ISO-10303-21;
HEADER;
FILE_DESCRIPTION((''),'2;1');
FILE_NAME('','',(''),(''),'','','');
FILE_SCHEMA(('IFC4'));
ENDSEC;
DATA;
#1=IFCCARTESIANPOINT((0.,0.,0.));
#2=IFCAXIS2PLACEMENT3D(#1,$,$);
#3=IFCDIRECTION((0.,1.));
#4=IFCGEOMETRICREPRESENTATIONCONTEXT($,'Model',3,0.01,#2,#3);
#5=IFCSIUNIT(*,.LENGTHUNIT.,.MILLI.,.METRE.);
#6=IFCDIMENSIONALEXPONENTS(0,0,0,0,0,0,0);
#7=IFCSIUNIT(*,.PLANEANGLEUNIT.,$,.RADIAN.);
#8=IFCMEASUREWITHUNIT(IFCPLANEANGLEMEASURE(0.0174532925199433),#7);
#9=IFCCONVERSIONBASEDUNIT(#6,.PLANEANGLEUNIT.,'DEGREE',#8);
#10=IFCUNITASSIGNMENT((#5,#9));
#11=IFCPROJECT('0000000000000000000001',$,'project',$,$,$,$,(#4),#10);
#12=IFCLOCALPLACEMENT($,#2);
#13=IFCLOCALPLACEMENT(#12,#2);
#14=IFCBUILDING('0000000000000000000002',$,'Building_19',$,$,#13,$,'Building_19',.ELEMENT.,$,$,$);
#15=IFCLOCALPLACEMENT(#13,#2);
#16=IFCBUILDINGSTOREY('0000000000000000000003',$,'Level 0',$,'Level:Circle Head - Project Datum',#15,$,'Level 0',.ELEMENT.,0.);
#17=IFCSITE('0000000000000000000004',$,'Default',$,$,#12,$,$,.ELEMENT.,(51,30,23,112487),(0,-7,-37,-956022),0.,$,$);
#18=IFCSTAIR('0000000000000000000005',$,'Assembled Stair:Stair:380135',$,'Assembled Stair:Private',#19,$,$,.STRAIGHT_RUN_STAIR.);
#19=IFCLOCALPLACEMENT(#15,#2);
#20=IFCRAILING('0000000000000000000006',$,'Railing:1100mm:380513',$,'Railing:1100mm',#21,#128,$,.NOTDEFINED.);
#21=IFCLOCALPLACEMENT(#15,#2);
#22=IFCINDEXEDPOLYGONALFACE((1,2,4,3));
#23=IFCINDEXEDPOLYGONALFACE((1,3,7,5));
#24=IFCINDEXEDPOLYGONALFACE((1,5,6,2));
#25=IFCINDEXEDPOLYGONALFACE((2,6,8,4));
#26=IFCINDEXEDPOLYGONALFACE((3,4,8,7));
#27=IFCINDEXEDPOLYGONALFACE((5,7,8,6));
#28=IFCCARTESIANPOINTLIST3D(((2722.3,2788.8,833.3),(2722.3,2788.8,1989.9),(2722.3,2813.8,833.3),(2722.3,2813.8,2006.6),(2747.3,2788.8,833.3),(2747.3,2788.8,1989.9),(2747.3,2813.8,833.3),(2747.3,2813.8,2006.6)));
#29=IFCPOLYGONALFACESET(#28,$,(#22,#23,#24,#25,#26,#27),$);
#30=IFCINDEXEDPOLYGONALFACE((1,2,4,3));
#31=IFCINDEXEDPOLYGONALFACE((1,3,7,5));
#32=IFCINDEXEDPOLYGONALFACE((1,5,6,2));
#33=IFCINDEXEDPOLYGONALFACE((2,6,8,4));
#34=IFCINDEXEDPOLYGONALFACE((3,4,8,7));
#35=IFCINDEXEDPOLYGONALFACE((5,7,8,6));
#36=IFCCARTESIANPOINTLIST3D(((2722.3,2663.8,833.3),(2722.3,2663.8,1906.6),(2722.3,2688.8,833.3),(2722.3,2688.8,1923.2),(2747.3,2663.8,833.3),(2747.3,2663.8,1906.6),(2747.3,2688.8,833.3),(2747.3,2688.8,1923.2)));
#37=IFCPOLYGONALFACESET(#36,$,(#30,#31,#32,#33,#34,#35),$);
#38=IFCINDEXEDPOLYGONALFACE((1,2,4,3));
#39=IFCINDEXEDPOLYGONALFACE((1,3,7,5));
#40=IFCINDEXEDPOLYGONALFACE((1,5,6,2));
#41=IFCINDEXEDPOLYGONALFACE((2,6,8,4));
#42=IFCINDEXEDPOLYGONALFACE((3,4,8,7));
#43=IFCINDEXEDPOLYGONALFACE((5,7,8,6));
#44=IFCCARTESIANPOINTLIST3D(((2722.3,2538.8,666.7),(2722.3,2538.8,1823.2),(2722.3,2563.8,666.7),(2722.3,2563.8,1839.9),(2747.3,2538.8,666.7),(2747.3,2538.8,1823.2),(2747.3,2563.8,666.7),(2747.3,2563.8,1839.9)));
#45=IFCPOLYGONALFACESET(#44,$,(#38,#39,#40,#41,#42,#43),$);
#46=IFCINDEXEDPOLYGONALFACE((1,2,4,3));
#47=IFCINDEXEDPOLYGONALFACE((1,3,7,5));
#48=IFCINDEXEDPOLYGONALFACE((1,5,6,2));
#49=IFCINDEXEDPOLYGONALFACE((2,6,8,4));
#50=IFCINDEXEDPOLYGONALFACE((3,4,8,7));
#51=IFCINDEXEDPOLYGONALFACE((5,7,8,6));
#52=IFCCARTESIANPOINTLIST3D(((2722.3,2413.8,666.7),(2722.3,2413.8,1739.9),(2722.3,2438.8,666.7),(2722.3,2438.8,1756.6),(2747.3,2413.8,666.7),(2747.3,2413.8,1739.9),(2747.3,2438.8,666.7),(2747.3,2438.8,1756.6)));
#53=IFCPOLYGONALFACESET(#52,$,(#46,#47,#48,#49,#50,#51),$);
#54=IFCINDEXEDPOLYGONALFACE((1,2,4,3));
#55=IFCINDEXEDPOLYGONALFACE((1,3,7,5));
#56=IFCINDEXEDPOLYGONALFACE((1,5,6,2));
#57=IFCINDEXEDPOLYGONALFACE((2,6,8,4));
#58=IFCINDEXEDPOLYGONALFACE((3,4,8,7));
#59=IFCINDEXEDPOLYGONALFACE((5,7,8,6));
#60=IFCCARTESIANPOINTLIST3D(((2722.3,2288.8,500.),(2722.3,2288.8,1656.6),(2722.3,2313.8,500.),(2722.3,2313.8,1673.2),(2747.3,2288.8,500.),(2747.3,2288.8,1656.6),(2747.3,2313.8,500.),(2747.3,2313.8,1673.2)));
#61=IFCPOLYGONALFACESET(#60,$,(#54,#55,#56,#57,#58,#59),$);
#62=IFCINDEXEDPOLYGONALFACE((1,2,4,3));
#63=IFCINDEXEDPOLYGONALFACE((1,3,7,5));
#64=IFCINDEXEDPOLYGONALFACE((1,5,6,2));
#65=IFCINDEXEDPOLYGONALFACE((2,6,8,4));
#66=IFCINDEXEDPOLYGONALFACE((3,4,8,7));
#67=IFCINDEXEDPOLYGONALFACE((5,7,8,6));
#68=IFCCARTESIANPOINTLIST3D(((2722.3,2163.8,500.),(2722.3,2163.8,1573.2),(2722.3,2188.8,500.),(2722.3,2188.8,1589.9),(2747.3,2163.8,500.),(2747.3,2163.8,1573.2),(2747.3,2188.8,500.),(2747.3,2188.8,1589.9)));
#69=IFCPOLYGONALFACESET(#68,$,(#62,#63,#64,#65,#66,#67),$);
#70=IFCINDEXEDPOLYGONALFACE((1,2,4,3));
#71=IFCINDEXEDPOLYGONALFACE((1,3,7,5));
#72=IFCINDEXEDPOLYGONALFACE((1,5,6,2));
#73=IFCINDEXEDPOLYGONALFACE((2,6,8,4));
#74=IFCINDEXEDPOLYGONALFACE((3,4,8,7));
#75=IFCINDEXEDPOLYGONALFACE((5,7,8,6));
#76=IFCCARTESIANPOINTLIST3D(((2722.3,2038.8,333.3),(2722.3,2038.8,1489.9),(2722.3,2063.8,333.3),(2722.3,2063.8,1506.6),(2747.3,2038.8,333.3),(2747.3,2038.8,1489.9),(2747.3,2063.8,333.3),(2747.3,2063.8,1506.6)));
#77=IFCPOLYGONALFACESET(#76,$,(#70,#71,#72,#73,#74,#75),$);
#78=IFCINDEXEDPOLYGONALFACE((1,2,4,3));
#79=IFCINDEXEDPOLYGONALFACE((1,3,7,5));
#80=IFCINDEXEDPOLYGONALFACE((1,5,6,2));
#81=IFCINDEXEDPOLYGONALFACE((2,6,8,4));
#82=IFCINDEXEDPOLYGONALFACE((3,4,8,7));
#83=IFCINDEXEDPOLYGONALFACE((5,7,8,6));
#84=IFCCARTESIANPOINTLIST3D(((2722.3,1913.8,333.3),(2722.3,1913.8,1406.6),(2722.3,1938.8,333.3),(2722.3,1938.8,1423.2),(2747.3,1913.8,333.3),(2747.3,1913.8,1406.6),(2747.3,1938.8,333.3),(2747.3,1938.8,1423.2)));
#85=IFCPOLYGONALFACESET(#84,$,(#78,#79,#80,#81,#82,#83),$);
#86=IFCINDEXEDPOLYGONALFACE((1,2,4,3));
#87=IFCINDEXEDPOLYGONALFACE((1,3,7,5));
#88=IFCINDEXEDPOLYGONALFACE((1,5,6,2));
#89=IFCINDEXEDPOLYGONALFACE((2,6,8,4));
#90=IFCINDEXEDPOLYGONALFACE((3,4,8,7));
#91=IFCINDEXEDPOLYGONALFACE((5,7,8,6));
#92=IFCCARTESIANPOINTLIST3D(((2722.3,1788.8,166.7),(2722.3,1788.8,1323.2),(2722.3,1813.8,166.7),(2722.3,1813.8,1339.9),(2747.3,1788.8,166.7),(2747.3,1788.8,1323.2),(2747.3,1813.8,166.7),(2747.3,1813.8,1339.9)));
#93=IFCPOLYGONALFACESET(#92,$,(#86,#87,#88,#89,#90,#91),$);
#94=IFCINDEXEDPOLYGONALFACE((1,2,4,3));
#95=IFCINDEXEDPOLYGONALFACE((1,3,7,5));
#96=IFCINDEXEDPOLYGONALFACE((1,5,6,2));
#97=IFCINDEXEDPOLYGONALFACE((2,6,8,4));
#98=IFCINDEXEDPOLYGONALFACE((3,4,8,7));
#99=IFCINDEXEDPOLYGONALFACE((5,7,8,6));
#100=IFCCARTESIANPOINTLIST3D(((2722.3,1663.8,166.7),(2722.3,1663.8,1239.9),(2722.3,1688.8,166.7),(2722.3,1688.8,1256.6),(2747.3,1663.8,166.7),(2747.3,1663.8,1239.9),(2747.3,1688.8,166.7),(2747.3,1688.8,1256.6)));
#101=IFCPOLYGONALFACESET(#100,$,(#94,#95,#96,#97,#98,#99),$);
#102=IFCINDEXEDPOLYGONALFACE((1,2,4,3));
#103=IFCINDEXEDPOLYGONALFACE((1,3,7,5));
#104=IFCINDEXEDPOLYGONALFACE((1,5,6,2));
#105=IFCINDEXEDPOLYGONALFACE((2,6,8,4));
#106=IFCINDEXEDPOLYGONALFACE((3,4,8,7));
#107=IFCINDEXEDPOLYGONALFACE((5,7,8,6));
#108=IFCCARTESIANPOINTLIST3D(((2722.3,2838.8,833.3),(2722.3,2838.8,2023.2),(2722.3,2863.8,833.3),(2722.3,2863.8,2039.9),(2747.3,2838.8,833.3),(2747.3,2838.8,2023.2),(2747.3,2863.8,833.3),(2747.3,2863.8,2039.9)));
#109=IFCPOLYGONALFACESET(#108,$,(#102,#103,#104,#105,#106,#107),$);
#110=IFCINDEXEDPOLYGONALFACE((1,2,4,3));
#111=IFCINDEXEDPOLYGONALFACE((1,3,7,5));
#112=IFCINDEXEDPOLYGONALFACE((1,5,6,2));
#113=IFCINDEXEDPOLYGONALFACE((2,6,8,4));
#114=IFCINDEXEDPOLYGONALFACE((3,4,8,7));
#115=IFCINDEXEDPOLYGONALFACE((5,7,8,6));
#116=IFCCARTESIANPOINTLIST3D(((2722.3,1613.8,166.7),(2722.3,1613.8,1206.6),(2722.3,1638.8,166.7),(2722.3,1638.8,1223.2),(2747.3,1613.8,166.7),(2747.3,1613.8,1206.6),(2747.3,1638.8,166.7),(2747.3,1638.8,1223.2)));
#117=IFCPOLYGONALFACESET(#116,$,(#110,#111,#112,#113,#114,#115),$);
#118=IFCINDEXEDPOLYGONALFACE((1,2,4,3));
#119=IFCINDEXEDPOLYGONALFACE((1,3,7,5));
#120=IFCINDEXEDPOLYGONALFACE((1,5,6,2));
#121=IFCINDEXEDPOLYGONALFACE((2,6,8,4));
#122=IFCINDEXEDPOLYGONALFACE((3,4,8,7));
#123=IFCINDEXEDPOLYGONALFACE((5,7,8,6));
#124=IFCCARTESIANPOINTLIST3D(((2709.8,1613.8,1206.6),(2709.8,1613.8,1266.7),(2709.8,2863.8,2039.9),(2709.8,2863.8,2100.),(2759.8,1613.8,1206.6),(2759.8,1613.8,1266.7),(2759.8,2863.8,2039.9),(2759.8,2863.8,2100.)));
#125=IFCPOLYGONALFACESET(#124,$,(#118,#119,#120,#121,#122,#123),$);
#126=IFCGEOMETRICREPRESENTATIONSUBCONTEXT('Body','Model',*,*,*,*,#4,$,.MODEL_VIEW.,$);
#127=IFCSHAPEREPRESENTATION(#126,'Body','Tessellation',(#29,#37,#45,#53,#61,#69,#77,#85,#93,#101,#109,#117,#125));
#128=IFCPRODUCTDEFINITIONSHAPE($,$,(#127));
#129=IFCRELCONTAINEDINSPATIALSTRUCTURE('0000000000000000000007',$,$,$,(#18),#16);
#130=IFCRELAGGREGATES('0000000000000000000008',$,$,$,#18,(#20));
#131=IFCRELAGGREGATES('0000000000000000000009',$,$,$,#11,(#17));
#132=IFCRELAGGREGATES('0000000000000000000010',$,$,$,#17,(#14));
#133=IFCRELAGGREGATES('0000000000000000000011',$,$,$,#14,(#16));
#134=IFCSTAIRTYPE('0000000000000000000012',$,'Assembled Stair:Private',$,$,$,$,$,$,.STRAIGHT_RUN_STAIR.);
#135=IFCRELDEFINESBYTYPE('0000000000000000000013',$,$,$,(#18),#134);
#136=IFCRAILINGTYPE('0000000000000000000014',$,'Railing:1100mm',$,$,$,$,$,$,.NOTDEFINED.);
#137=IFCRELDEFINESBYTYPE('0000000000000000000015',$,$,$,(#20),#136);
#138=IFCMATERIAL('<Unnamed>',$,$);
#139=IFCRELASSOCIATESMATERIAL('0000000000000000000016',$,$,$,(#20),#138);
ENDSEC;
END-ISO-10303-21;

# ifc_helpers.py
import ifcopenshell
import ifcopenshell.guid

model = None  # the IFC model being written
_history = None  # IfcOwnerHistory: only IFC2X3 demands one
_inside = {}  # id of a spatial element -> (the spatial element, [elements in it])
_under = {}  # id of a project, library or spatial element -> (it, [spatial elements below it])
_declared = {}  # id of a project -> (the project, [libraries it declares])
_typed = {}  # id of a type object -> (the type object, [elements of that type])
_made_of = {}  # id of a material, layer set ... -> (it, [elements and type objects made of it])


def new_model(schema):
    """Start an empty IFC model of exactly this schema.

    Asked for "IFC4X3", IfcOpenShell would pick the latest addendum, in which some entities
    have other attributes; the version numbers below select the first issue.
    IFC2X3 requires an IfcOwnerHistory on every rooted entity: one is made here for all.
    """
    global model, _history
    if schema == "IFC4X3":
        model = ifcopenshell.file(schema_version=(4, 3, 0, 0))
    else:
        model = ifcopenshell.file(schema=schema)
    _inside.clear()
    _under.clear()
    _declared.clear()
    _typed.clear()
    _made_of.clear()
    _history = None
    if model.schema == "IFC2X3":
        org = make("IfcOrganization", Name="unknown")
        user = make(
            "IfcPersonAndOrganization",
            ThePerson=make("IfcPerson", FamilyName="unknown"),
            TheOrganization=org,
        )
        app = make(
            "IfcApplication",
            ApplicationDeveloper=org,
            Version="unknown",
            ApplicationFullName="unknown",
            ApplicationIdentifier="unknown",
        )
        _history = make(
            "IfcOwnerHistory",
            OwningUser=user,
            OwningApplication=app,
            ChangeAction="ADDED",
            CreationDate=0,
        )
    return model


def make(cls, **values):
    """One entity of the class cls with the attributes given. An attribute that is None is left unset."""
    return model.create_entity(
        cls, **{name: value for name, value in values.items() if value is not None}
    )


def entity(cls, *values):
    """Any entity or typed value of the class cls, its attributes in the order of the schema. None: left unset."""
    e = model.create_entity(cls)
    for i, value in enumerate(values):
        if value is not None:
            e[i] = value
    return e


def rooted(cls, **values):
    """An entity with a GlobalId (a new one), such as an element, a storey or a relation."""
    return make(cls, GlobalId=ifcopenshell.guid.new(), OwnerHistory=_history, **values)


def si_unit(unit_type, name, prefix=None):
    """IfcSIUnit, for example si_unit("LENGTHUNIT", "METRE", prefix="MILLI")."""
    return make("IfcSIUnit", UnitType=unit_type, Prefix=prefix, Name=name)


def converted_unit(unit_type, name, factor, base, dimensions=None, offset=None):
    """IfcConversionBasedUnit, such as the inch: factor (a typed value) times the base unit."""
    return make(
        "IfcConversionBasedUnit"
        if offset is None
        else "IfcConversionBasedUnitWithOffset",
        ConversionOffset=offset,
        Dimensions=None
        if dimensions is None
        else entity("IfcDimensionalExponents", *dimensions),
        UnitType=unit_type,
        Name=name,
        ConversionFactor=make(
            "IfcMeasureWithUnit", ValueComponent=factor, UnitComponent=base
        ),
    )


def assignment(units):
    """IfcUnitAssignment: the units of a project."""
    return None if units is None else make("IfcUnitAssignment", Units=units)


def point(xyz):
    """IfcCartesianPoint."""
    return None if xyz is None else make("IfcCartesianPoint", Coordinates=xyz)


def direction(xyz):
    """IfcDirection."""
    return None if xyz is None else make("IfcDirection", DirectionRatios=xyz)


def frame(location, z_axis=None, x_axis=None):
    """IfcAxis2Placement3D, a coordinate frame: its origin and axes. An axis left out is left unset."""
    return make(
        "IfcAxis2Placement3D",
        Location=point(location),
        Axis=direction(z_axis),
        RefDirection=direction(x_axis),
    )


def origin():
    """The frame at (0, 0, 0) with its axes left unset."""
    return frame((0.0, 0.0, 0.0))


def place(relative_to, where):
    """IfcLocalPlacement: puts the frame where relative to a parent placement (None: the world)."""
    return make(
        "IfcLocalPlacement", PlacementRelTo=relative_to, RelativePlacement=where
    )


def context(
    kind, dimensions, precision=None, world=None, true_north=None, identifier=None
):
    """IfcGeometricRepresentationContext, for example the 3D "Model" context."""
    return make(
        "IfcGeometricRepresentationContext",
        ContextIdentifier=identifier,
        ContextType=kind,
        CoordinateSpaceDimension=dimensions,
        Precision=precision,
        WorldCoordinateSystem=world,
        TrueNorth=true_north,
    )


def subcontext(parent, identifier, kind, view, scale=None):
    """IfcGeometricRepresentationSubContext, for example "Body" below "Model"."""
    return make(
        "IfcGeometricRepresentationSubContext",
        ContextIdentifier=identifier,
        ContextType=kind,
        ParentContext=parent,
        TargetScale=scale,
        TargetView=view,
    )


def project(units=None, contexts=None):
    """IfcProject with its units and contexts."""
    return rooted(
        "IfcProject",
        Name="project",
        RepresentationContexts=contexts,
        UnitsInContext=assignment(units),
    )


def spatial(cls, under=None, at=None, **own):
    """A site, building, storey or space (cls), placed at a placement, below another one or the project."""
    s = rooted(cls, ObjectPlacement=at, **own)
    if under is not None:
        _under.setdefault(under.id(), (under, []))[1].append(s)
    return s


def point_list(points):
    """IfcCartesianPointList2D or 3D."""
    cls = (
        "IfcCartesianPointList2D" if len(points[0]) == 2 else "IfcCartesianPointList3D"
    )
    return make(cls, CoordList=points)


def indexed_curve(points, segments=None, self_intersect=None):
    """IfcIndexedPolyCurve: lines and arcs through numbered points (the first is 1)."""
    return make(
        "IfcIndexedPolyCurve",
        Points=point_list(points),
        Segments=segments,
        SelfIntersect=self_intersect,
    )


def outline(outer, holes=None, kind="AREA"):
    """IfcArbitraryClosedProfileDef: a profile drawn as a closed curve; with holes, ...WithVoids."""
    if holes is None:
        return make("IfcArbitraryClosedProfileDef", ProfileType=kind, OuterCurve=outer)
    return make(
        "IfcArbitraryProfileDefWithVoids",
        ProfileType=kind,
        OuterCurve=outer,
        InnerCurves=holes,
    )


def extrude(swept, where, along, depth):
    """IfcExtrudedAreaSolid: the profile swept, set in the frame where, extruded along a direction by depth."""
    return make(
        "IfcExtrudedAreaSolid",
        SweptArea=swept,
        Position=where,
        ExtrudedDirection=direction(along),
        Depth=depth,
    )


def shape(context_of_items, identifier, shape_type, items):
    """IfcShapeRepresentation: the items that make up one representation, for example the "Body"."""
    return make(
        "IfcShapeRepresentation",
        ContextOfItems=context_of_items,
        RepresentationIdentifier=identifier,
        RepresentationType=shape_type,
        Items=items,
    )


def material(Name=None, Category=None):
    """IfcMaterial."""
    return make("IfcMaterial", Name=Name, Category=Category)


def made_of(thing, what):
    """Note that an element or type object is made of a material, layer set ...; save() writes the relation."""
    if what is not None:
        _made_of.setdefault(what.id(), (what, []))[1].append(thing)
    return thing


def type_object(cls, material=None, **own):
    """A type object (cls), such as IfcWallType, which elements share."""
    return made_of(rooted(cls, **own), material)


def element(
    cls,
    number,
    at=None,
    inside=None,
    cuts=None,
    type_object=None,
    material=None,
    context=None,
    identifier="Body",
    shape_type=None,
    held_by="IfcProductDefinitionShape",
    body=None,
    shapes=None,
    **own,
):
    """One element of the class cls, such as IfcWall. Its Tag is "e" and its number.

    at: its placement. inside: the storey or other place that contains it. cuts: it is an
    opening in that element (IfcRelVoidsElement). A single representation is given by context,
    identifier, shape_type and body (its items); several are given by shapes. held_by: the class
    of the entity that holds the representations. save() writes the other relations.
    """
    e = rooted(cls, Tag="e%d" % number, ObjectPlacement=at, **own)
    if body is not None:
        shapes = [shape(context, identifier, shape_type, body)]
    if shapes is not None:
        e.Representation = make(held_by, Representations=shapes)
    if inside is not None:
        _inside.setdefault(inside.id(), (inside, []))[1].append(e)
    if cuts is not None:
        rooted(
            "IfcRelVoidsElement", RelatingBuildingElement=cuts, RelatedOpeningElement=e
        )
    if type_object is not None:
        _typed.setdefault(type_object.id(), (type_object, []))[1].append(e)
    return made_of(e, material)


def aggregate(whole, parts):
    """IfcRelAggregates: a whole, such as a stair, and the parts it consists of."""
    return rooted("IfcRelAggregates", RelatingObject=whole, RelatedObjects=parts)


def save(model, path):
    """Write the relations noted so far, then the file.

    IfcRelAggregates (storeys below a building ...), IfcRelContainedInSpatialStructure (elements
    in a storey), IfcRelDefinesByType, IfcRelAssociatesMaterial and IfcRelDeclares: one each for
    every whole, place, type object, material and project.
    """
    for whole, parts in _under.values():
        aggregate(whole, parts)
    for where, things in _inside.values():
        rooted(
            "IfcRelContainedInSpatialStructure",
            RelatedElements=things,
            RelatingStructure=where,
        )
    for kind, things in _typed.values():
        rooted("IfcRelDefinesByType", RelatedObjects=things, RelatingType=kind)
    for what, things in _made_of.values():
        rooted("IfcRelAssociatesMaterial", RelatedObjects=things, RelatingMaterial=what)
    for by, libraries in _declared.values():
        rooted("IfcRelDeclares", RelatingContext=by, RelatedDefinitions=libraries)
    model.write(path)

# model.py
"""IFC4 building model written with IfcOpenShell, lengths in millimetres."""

from ifc_helpers import new_model, entity, si_unit, converted_unit, direction, frame, origin, place, context, subcontext, project, spatial, indexed_curve, outline, extrude, material, type_object, element, aggregate, save


model = new_model("IFC4")

# Units and contexts
model_context = context("Model", 3, precision=0.01, world=origin(), true_north=direction((0.0, 1.0)))
body_context = subcontext(model_context, "Body", "Model", "MODEL_VIEW")
ifc_project = project(units=[si_unit("LENGTHUNIT", "METRE", prefix="MILLI"), converted_unit("PLANEANGLEUNIT", "DEGREE", entity("IfcPlaneAngleMeasure", 0.0174532925199433), si_unit("PLANEANGLEUNIT", "RADIAN"), dimensions=[0, 0, 0, 0, 0, 0, 0])], contexts=[model_context])

# Site, building, storey
site_placement = place(None, origin())
site = spatial("IfcSite", under=ifc_project, at=site_placement, Name="Default", CompositionType="ELEMENT", RefLatitude=(51, 30, 23, 112487), RefLongitude=(0, -7, -37, -956022), RefElevation=0.0)
building_placement = place(site_placement, origin())
building = spatial("IfcBuilding", under=site, at=building_placement, Name="Building_19", LongName="Building_19", CompositionType="ELEMENT")
storey_placement = place(building_placement, origin())
storey = spatial("IfcBuildingStorey", under=building, at=storey_placement, Name="Level 0", ObjectType="Level:Circle Head - Project Datum", LongName="Level 0", CompositionType="ELEMENT", Elevation=0.0)

# Stair, railing
stair_type = type_object("IfcStairType", Name="Assembled Stair:Private", PredefinedType="STRAIGHT_RUN_STAIR")
ifc_material_1 = material(Name="<Unnamed>")
railing_type = type_object("IfcRailingType", Name="Railing:1100mm", PredefinedType="NOTDEFINED")
stair_1_placement = place(storey_placement, origin())
stair_1 = element("IfcStair", 1, at=stair_1_placement, inside=storey, type_object=stair_type, Name="Assembled Stair:Stair:380135", ObjectType="Assembled Stair:Private", PredefinedType="STRAIGHT_RUN_STAIR")
railing_1_placement = place(stair_1_placement, origin())
railing_1 = element("IfcRailing", 2, at=railing_1_placement, type_object=railing_type, material=ifc_material_1, Name="Railing:1100mm:380513", ObjectType="Railing:1100mm", PredefinedType="NOTDEFINED", context=body_context, shape_type="SweptSolid", body=[
    extrude(outline(indexed_curve([(-574.1, -12.5), (582.5, -12.5), (582.5, 12.5), (-590.8, 12.5), (-574.1, -12.5)], self_intersect=False)), frame((2722.3, 2801.3, 1415.8), z_axis=(1.0, 0.0, 0.0), x_axis=(0.0, 0.0, -1.0)), (0.0, 0.0, 1.0), 25.0),
    extrude(outline(indexed_curve([(-532.5, -12.5), (540.8, -12.5), (540.8, 12.5), (-549.1, 12.5), (-532.5, -12.5)], self_intersect=False)), frame((2722.3, 2676.3, 1374.1), z_axis=(1.0, 0.0, 0.0), x_axis=(0.0, 0.0, -1.0)), (0.0, 0.0, 1.0), 25.0),
    extrude(outline(indexed_curve([(-574.1, -12.5), (582.5, -12.5), (582.5, 12.5), (-590.8, 12.5), (-574.1, -12.5)], self_intersect=False)), frame((2722.3, 2551.3, 1249.1), z_axis=(1.0, 0.0, 0.0), x_axis=(0.0, 0.0, -1.0)), (0.0, 0.0, 1.0), 25.0),
    extrude(outline(indexed_curve([(-532.5, -12.5), (540.8, -12.5), (540.8, 12.5), (-549.1, 12.5), (-532.5, -12.5)], self_intersect=False)), frame((2722.3, 2426.3, 1207.5), z_axis=(1.0, 0.0, 0.0), x_axis=(0.0, 0.0, -1.0)), (0.0, 0.0, 1.0), 25.0),
    extrude(outline(indexed_curve([(-574.1, -12.5), (582.5, -12.5), (582.5, 12.5), (-590.8, 12.5), (-574.1, -12.5)], self_intersect=False)), frame((2722.3, 2301.3, 1082.5), z_axis=(1.0, 0.0, 0.0), x_axis=(0.0, 0.0, -1.0)), (0.0, 0.0, 1.0), 25.0),
    extrude(outline(indexed_curve([(-532.5, -12.5), (540.8, -12.5), (540.8, 12.5), (-549.1, 12.5), (-532.5, -12.5)], self_intersect=False)), frame((2722.3, 2176.3, 1040.8), z_axis=(1.0, 0.0, 0.0), x_axis=(0.0, 0.0, -1.0)), (0.0, 0.0, 1.0), 25.0),
    extrude(outline(indexed_curve([(-574.1, -12.5), (582.5, -12.5), (582.5, 12.5), (-590.8, 12.5), (-574.1, -12.5)], self_intersect=False)), frame((2722.3, 2051.3, 915.8), z_axis=(1.0, 0.0, 0.0), x_axis=(0.0, 0.0, -1.0)), (0.0, 0.0, 1.0), 25.0),
    extrude(outline(indexed_curve([(-532.5, -12.5), (540.8, -12.5), (540.8, 12.5), (-549.1, 12.5), (-532.5, -12.5)], self_intersect=False)), frame((2722.3, 1926.3, 874.1), z_axis=(1.0, 0.0, 0.0), x_axis=(0.0, 0.0, -1.0)), (0.0, 0.0, 1.0), 25.0),
    extrude(outline(indexed_curve([(-574.1, -12.5), (582.5, -12.5), (582.5, 12.5), (-590.8, 12.5), (-574.1, -12.5)], self_intersect=False)), frame((2722.3, 1801.3, 749.1), z_axis=(1.0, 0.0, 0.0), x_axis=(0.0, 0.0, -1.0)), (0.0, 0.0, 1.0), 25.0),
    extrude(outline(indexed_curve([(-532.5, -12.5), (540.8, -12.5), (540.8, 12.5), (-549.1, 12.5), (-532.5, -12.5)], self_intersect=False)), frame((2722.3, 1676.3, 707.5), z_axis=(1.0, 0.0, 0.0), x_axis=(0.0, 0.0, -1.0)), (0.0, 0.0, 1.0), 25.0),
    extrude(outline(indexed_curve([(-590.8, -12.5), (599.1, -12.5), (599.1, 12.5), (-607.5, 12.5), (-590.8, -12.5)], self_intersect=False)), frame((2722.3, 2851.3, 1432.5), z_axis=(1.0, 0.0, 0.0), x_axis=(0.0, 0.0, -1.0)), (0.0, 0.0, 1.0), 25.0),
    extrude(outline(indexed_curve([(-515.8, -12.5), (524.1, -12.5), (524.1, 12.5), (-532.5, 12.5), (-515.8, -12.5)], self_intersect=False)), frame((2722.3, 1626.3, 690.8), z_axis=(1.0, 0.0, 0.0), x_axis=(0.0, 0.0, -1.0)), (0.0, 0.0, 1.0), 25.0),
    extrude(outline(indexed_curve([(-767.8, -25.0), (734.5, -25.0), (767.8, 25.0), (-734.5, 25.0), (-767.8, -25.0)], self_intersect=False)), frame((2709.8, 2238.8, 1653.3), z_axis=(1.0, 0.0, 0.0), x_axis=(0.0, 0.83205, 0.5547)), (0.0, 0.0, 1.0), 50.0),
])
aggregate(stair_1, [railing_1])

save(model, "model.ifc")
